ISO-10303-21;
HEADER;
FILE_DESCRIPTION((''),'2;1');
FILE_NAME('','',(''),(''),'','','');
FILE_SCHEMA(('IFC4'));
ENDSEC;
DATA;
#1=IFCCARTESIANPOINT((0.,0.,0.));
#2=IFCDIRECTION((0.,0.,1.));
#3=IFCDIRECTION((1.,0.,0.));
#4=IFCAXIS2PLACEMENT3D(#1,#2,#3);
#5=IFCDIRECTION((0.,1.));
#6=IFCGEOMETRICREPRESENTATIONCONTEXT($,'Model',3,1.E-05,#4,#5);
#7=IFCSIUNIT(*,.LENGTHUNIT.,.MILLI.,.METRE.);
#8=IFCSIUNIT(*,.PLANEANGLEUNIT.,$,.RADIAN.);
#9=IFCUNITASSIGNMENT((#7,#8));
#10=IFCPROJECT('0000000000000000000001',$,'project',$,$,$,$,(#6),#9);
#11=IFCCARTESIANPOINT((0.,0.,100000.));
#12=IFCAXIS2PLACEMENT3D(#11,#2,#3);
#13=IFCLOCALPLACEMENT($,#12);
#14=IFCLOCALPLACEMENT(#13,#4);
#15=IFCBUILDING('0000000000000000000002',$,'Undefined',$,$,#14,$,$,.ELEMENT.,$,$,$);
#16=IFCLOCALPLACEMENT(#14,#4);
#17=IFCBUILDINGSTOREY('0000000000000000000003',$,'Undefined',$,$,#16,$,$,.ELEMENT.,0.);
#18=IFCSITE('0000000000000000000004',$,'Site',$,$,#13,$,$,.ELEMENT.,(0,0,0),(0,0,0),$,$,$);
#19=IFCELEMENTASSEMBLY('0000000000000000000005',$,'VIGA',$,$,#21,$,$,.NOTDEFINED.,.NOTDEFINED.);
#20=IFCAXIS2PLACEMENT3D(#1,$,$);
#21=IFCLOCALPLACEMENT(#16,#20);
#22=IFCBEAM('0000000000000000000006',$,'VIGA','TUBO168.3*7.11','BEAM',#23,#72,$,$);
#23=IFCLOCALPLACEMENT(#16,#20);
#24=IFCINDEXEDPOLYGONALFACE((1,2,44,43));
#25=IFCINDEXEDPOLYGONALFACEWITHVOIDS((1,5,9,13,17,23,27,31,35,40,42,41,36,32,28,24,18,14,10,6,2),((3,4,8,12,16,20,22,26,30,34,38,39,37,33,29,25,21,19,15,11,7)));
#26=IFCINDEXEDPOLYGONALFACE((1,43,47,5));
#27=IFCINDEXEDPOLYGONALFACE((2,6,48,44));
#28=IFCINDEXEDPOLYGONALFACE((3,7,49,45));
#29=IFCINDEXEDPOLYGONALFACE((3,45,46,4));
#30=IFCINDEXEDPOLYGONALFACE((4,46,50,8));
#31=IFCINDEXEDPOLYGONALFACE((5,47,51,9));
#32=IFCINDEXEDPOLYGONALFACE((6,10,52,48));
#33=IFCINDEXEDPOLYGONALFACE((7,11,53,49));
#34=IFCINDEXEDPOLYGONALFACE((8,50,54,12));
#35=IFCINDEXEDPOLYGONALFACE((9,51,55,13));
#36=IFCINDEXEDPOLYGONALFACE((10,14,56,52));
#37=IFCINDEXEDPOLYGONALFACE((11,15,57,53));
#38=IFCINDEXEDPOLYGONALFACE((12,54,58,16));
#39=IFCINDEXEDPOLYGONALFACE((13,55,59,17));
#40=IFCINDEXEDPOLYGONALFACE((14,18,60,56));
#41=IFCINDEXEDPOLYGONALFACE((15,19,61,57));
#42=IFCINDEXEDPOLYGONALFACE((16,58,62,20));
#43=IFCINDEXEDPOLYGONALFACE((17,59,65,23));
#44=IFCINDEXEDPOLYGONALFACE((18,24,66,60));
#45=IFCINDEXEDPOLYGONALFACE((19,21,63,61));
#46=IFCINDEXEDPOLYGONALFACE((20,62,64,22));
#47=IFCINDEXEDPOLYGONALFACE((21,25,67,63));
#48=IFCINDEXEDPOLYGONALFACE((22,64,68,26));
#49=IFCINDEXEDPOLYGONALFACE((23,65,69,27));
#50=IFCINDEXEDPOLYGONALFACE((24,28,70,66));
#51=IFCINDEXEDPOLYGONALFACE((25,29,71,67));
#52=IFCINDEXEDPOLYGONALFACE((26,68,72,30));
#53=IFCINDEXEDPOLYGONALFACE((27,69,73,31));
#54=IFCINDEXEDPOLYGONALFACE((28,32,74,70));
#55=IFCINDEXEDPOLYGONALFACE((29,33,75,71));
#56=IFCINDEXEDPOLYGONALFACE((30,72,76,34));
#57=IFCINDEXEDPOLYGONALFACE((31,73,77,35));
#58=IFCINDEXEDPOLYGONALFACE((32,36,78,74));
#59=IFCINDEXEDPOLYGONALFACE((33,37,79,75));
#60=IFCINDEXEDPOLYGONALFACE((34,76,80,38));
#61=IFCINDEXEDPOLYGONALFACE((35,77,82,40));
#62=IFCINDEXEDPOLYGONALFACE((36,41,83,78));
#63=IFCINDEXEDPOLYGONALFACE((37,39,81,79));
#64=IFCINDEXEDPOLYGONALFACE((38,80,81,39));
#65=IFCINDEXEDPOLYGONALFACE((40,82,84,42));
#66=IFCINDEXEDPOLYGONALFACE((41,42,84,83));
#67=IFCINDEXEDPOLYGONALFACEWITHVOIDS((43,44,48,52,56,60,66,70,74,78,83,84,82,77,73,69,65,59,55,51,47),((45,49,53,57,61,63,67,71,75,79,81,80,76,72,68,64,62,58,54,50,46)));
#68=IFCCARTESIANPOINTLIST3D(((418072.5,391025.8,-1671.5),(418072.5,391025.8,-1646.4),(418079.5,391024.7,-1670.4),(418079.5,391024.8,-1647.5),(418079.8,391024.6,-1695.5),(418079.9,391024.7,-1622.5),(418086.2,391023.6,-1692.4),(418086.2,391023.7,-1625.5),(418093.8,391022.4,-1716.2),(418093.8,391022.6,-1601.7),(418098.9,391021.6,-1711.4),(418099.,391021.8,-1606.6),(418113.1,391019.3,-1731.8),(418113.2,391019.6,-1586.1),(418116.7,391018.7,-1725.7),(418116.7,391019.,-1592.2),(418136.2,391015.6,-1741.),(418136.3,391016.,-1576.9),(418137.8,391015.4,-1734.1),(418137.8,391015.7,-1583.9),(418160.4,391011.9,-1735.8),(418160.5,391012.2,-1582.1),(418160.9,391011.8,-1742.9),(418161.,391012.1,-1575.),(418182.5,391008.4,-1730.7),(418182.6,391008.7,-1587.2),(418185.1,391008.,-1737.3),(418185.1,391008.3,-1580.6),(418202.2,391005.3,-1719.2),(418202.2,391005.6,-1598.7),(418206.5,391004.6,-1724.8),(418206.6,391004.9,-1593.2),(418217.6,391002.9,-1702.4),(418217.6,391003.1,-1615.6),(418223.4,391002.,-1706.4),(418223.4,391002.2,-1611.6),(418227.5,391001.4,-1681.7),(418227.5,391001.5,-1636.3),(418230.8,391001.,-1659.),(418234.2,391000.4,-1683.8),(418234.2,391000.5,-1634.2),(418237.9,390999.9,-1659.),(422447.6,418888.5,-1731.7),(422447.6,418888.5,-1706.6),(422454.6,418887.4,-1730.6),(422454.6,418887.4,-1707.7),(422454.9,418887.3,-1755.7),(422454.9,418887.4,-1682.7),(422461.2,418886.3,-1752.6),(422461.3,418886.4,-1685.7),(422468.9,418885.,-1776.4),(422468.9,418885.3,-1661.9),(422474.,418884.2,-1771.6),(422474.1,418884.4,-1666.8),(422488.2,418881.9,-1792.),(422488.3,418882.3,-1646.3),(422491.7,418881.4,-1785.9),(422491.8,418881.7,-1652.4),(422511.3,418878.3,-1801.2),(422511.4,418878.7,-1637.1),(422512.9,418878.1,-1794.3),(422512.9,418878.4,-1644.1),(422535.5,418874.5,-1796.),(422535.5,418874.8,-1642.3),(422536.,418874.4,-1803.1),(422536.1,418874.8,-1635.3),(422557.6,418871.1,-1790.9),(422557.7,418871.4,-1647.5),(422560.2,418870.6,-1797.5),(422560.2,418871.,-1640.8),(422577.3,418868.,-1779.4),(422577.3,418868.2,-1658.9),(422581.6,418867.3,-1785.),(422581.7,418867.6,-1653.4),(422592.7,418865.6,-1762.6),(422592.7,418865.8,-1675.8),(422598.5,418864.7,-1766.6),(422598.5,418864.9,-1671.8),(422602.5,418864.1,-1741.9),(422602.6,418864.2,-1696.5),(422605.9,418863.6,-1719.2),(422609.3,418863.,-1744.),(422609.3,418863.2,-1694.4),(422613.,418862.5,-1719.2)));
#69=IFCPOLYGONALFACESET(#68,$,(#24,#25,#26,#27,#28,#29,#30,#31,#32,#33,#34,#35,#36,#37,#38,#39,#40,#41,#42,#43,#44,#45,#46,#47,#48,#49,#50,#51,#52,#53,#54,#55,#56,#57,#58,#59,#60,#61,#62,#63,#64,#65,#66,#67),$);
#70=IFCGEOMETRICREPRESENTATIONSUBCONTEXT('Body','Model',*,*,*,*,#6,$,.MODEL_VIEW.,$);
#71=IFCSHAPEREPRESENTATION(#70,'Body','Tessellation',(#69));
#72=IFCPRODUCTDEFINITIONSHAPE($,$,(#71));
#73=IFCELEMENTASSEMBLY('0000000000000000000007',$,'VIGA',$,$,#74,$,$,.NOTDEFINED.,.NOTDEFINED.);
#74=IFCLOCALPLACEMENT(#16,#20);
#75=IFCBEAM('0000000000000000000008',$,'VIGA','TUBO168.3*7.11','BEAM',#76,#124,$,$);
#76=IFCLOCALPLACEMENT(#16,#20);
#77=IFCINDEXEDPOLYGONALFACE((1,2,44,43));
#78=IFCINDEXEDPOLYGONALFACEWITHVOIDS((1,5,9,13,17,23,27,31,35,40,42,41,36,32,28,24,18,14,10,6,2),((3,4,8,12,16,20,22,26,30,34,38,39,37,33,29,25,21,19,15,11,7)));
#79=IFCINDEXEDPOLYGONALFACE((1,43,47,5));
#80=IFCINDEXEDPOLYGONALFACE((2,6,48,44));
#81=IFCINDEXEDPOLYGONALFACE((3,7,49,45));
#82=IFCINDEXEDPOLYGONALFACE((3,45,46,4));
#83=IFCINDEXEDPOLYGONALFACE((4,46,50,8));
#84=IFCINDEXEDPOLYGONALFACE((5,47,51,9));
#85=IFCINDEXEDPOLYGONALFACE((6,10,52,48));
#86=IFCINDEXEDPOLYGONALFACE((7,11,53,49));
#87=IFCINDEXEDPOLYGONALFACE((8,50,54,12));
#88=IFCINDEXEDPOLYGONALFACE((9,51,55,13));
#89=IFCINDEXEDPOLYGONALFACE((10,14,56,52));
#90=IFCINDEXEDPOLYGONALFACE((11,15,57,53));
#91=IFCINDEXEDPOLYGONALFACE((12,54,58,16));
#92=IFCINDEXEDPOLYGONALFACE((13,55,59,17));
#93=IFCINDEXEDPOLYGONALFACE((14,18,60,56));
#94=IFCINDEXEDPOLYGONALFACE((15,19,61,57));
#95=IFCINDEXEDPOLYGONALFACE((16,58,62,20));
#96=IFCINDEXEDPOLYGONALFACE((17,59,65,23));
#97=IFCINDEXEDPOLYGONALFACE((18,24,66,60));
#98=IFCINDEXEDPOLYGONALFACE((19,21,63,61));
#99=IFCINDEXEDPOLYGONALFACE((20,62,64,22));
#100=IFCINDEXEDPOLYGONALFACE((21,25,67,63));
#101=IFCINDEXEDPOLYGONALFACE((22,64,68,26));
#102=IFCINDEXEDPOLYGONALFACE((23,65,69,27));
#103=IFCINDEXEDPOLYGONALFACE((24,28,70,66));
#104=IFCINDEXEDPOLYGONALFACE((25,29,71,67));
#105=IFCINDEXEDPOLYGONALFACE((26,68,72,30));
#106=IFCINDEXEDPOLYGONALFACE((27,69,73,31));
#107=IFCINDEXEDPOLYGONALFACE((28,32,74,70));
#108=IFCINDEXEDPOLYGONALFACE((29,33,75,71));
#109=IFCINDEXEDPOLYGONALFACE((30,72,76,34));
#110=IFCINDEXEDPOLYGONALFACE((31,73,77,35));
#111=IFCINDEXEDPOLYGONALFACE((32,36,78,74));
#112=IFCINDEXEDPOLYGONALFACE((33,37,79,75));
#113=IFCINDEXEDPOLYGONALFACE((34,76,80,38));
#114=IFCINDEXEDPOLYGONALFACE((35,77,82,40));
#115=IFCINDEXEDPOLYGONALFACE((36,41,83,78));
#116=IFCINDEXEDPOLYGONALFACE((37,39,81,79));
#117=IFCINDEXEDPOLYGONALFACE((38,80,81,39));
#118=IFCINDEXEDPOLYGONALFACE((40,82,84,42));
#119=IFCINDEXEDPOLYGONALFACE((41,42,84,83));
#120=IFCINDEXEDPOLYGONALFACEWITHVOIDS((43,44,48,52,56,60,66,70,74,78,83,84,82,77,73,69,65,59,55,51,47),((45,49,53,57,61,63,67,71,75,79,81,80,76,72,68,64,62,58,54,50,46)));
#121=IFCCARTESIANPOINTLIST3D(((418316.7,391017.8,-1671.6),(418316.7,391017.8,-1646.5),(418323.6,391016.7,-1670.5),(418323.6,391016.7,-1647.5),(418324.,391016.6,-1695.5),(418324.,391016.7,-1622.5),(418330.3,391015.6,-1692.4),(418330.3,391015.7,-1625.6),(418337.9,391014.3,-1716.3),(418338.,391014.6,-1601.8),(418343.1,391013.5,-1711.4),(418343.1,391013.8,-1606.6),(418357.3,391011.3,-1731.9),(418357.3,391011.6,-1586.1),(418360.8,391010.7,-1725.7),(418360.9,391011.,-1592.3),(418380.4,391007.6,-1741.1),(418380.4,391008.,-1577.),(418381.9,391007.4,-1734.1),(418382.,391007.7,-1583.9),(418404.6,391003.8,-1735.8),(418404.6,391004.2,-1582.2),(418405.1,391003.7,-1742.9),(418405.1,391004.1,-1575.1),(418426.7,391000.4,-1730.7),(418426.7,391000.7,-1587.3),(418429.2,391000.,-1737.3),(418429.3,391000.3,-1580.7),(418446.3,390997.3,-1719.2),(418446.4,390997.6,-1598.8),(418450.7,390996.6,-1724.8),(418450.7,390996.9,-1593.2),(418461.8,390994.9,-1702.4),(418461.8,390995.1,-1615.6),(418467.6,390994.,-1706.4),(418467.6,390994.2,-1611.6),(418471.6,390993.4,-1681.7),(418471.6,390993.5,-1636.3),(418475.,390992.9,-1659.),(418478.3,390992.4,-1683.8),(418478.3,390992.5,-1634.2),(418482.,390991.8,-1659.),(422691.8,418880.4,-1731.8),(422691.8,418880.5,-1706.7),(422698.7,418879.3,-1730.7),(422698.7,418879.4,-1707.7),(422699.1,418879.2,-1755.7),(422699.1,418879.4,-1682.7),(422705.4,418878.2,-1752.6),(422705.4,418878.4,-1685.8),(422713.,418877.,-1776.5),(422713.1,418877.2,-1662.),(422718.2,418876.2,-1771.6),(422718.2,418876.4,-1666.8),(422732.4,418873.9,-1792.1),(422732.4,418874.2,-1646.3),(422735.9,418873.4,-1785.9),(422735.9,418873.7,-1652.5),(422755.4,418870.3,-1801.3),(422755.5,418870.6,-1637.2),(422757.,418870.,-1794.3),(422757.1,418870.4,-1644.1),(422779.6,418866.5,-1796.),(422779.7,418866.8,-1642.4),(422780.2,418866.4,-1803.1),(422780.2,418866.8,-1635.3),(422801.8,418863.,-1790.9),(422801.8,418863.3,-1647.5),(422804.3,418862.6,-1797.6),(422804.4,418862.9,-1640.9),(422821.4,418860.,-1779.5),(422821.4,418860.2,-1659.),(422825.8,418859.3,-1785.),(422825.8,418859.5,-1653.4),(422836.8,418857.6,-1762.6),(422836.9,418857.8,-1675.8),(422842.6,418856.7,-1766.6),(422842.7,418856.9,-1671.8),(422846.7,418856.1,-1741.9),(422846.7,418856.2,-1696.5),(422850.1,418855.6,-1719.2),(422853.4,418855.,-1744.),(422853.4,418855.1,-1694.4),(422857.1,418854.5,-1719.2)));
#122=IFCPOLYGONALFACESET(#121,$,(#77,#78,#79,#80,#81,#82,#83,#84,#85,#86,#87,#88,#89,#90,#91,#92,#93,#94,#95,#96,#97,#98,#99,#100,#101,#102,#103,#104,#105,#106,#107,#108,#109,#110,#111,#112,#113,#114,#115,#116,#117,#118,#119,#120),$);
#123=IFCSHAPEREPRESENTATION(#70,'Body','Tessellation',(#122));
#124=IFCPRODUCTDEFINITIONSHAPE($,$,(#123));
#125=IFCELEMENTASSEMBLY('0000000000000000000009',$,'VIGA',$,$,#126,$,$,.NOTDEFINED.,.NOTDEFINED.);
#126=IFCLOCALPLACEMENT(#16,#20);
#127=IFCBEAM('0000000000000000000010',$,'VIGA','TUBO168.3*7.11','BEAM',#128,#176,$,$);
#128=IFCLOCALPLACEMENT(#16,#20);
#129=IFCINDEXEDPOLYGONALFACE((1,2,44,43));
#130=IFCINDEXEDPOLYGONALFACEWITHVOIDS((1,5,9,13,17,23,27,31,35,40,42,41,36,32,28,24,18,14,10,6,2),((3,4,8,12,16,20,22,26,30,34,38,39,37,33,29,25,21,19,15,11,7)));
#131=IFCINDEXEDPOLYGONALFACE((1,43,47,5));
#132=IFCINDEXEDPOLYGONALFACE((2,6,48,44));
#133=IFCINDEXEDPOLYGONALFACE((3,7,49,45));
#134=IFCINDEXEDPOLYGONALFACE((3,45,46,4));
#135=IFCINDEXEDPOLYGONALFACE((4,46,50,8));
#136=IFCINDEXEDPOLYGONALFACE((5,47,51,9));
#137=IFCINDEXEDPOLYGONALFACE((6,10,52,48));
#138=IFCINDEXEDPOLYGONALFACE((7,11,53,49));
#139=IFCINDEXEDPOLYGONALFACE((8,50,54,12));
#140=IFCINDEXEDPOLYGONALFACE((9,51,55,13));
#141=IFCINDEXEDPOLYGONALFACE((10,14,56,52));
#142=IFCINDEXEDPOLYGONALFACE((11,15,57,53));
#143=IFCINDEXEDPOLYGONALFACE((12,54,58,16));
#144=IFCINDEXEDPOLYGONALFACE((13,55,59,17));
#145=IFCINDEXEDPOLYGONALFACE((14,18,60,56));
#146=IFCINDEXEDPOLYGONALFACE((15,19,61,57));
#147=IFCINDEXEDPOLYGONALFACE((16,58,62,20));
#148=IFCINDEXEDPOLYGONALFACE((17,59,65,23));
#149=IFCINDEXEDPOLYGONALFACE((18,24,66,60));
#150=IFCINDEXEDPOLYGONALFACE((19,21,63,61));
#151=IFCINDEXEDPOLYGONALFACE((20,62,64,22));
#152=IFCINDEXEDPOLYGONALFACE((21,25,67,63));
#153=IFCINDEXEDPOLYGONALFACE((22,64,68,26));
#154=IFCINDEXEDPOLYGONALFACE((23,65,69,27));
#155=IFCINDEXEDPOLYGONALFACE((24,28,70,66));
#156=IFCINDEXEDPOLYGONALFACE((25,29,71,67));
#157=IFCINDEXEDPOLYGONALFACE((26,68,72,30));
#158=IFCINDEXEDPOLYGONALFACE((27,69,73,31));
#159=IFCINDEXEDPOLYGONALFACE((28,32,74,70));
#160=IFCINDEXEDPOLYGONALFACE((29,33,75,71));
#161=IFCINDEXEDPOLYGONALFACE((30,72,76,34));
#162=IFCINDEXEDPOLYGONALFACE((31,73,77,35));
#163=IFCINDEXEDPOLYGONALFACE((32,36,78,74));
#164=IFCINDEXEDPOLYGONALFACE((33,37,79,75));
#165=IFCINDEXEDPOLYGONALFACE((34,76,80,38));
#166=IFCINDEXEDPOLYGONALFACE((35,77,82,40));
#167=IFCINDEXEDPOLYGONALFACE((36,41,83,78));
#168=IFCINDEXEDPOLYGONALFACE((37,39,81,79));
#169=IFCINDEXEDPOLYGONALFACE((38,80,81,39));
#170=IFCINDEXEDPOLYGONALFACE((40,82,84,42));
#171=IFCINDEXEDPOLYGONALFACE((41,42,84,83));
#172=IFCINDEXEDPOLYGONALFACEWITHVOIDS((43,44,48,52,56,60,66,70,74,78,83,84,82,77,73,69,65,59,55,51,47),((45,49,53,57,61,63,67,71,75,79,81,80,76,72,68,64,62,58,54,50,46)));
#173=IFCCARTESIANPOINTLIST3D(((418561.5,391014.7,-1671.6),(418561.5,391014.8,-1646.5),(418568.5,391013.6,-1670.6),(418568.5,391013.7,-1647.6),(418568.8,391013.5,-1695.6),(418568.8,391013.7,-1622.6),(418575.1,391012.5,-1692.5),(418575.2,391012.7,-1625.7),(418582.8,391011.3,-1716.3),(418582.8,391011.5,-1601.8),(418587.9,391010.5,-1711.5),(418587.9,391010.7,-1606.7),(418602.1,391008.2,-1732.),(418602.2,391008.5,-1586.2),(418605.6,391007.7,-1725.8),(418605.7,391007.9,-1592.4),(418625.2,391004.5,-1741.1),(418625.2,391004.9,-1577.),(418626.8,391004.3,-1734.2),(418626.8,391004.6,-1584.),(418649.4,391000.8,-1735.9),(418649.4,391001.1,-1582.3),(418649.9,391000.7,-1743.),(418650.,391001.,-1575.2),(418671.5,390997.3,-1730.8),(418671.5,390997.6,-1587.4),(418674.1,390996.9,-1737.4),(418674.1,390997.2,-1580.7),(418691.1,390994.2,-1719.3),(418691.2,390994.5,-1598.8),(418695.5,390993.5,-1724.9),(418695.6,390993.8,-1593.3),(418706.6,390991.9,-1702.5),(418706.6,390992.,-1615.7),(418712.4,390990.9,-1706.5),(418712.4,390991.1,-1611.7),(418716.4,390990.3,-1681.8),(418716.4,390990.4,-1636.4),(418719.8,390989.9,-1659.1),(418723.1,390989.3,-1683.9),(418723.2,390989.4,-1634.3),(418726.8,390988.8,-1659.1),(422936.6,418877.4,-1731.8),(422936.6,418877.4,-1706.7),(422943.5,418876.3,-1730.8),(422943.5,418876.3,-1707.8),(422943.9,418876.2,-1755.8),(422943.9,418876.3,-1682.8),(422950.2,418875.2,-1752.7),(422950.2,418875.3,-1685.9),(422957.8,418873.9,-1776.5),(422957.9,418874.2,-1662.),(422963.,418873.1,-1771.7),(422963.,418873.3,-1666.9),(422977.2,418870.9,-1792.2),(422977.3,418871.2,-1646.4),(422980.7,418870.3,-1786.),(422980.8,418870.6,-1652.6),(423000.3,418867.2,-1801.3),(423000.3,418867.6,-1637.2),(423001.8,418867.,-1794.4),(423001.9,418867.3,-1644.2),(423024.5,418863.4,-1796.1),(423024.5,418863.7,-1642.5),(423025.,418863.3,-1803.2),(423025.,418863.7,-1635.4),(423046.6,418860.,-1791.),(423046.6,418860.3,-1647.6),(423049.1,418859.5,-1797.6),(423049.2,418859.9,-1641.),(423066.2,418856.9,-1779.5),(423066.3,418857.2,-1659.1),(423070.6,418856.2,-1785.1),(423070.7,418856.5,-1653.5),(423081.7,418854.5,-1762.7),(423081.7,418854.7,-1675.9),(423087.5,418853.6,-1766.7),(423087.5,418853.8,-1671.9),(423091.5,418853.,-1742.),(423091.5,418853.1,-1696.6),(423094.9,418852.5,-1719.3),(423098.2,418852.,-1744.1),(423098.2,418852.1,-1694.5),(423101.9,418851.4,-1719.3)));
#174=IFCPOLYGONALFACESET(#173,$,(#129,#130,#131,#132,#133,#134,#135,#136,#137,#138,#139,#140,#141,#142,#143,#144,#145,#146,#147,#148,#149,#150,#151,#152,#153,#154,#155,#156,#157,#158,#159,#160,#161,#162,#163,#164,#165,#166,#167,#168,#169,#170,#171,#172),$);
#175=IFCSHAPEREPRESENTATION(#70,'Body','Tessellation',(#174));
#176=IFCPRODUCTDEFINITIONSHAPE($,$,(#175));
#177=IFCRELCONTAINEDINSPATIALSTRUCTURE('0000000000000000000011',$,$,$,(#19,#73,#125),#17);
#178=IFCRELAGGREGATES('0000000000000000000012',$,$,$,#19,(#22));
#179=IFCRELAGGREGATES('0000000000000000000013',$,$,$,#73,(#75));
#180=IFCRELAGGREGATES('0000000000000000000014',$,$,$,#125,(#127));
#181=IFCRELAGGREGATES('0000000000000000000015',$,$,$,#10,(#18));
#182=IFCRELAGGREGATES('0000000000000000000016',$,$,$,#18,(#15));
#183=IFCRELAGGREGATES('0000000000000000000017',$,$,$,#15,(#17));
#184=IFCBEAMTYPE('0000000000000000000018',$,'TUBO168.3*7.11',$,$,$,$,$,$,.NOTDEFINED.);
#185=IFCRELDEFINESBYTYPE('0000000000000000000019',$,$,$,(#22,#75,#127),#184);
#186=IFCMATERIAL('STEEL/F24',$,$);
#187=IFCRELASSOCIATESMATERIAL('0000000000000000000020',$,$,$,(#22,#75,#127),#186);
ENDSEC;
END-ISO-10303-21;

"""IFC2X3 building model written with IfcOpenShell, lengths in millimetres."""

from ifc_helpers import new_model, si_unit, direction, frame, origin_with_axes, origin_2d_with_axis, place, context, subcontext, project, spatial, hollow_circle, extrude, material, type_object, element, aggregate, save


model = new_model("IFC2X3")

# Units and contexts
model_context = context("Model", 3, precision=1e-05, world=origin_with_axes(), true_north=direction((0.0, 1.0)))
body_context = subcontext(model_context, "Body", "Model", "MODEL_VIEW")
ifc_project = project(units=[si_unit("LENGTHUNIT", "METRE", prefix="MILLI"), si_unit("PLANEANGLEUNIT", "RADIAN")], contexts=[model_context])

# Site, building, storey
site_placement = place(None, frame((0.0, 0.0, 100000.0), z_axis=(0.0, 0.0, 1.0), x_axis=(1.0, 0.0, 0.0)))
site = spatial("IfcSite", under=ifc_project, at=site_placement, Name="Site", CompositionType="ELEMENT", RefLatitude=(0, 0, 0), RefLongitude=(0, 0, 0))
building_placement = place(site_placement, origin_with_axes())
building = spatial("IfcBuilding", under=site, at=building_placement, Name="Undefined", CompositionType="ELEMENT")
storey_placement = place(building_placement, origin_with_axes())
storey = spatial("IfcBuildingStorey", under=building, at=storey_placement, Name="Undefined", CompositionType="ELEMENT", Elevation=0.0)

# Element assemblies, beams
ifc_material_1 = material(Name="STEEL/F24")
beam_type_1 = type_object("IfcBeamType", Name="TUBO168.3*7.11", PredefinedType="NOTDEFINED")
assembly_1_placement = place(storey_placement, origin_with_axes())
assembly_1 = element("IfcElementAssembly", 1, at=assembly_1_placement, inside=storey, Name="VIGA", AssemblyPlace="NOTDEFINED", PredefinedType="NOTDEFINED")
beam_1_placement = place(assembly_1_placement, frame((418154.7, 391012.9, -1659.0), z_axis=(0.000331, 0.002109, 0.999998), x_axis=(0.155122, 0.987893, -0.002135)))
beam_1 = element("IfcBeam", 2, at=beam_1_placement, type_object=beam_type_1, material=ifc_material_1, Name="VIGA", Description="TUBO168.3*7.11", ObjectType="BEAM", context=body_context, shape_type="SweptSolid", body=[
    extrude(hollow_circle(Radius=84.2, WallThickness=7.1, at=origin_2d_with_axis()), frame((28204.1, 0.0, 0.0), z_axis=(-1.0, 0.0, 0.0), x_axis=(0.0, -1.0, 0.0)), (0.0, 0.0, 1.0), 28204.1),
])
aggregate(assembly_1, [beam_1])
assembly_2_placement = place(storey_placement, origin_with_axes())
assembly_2 = element("IfcElementAssembly", 3, at=assembly_2_placement, inside=storey, Name="VIGA", AssemblyPlace="NOTDEFINED", PredefinedType="NOTDEFINED")
beam_2_placement = place(assembly_2_placement, frame((418398.9, 391004.9, -1659.0), z_axis=(0.000331, 0.002109, 0.999998), x_axis=(0.155122, 0.987893, -0.002135)))
beam_2 = element("IfcBeam", 4, at=beam_2_placement, type_object=beam_type_1, material=ifc_material_1, Name="VIGA", Description="TUBO168.3*7.11", ObjectType="BEAM", context=body_context, shape_type="SweptSolid", body=[
    extrude(hollow_circle(Radius=84.2, WallThickness=7.1, at=origin_2d_with_axis()), frame((28204.1, 0.0, 0.0), z_axis=(-1.0, 0.0, 0.0), x_axis=(0.0, -1.0, 0.0)), (0.0, 0.0, 1.0), 28204.1),
])
aggregate(assembly_2, [beam_2])
assembly_3_placement = place(storey_placement, origin_with_axes())
assembly_3 = element("IfcElementAssembly", 5, at=assembly_3_placement, inside=storey, Name="VIGA", AssemblyPlace="NOTDEFINED", PredefinedType="NOTDEFINED")
beam_3_placement = place(assembly_3_placement, frame((418643.7, 391001.8, -1659.1), z_axis=(0.000331, 0.002109, 0.999998), x_axis=(0.155122, 0.987893, -0.002135)))
beam_3 = element("IfcBeam", 6, at=beam_3_placement, type_object=beam_type_1, material=ifc_material_1, Name="VIGA", Description="TUBO168.3*7.11", ObjectType="BEAM", context=body_context, shape_type="SweptSolid", body=[
    extrude(hollow_circle(Radius=84.2, WallThickness=7.1, at=origin_2d_with_axis()), frame((28204.1, 0.0, 0.0), z_axis=(-1.0, 0.0, 0.0), x_axis=(0.0, -1.0, 0.0)), (0.0, 0.0, 1.0), 28204.1),
])
aggregate(assembly_3, [beam_3])

save(model, "model.ifc")
